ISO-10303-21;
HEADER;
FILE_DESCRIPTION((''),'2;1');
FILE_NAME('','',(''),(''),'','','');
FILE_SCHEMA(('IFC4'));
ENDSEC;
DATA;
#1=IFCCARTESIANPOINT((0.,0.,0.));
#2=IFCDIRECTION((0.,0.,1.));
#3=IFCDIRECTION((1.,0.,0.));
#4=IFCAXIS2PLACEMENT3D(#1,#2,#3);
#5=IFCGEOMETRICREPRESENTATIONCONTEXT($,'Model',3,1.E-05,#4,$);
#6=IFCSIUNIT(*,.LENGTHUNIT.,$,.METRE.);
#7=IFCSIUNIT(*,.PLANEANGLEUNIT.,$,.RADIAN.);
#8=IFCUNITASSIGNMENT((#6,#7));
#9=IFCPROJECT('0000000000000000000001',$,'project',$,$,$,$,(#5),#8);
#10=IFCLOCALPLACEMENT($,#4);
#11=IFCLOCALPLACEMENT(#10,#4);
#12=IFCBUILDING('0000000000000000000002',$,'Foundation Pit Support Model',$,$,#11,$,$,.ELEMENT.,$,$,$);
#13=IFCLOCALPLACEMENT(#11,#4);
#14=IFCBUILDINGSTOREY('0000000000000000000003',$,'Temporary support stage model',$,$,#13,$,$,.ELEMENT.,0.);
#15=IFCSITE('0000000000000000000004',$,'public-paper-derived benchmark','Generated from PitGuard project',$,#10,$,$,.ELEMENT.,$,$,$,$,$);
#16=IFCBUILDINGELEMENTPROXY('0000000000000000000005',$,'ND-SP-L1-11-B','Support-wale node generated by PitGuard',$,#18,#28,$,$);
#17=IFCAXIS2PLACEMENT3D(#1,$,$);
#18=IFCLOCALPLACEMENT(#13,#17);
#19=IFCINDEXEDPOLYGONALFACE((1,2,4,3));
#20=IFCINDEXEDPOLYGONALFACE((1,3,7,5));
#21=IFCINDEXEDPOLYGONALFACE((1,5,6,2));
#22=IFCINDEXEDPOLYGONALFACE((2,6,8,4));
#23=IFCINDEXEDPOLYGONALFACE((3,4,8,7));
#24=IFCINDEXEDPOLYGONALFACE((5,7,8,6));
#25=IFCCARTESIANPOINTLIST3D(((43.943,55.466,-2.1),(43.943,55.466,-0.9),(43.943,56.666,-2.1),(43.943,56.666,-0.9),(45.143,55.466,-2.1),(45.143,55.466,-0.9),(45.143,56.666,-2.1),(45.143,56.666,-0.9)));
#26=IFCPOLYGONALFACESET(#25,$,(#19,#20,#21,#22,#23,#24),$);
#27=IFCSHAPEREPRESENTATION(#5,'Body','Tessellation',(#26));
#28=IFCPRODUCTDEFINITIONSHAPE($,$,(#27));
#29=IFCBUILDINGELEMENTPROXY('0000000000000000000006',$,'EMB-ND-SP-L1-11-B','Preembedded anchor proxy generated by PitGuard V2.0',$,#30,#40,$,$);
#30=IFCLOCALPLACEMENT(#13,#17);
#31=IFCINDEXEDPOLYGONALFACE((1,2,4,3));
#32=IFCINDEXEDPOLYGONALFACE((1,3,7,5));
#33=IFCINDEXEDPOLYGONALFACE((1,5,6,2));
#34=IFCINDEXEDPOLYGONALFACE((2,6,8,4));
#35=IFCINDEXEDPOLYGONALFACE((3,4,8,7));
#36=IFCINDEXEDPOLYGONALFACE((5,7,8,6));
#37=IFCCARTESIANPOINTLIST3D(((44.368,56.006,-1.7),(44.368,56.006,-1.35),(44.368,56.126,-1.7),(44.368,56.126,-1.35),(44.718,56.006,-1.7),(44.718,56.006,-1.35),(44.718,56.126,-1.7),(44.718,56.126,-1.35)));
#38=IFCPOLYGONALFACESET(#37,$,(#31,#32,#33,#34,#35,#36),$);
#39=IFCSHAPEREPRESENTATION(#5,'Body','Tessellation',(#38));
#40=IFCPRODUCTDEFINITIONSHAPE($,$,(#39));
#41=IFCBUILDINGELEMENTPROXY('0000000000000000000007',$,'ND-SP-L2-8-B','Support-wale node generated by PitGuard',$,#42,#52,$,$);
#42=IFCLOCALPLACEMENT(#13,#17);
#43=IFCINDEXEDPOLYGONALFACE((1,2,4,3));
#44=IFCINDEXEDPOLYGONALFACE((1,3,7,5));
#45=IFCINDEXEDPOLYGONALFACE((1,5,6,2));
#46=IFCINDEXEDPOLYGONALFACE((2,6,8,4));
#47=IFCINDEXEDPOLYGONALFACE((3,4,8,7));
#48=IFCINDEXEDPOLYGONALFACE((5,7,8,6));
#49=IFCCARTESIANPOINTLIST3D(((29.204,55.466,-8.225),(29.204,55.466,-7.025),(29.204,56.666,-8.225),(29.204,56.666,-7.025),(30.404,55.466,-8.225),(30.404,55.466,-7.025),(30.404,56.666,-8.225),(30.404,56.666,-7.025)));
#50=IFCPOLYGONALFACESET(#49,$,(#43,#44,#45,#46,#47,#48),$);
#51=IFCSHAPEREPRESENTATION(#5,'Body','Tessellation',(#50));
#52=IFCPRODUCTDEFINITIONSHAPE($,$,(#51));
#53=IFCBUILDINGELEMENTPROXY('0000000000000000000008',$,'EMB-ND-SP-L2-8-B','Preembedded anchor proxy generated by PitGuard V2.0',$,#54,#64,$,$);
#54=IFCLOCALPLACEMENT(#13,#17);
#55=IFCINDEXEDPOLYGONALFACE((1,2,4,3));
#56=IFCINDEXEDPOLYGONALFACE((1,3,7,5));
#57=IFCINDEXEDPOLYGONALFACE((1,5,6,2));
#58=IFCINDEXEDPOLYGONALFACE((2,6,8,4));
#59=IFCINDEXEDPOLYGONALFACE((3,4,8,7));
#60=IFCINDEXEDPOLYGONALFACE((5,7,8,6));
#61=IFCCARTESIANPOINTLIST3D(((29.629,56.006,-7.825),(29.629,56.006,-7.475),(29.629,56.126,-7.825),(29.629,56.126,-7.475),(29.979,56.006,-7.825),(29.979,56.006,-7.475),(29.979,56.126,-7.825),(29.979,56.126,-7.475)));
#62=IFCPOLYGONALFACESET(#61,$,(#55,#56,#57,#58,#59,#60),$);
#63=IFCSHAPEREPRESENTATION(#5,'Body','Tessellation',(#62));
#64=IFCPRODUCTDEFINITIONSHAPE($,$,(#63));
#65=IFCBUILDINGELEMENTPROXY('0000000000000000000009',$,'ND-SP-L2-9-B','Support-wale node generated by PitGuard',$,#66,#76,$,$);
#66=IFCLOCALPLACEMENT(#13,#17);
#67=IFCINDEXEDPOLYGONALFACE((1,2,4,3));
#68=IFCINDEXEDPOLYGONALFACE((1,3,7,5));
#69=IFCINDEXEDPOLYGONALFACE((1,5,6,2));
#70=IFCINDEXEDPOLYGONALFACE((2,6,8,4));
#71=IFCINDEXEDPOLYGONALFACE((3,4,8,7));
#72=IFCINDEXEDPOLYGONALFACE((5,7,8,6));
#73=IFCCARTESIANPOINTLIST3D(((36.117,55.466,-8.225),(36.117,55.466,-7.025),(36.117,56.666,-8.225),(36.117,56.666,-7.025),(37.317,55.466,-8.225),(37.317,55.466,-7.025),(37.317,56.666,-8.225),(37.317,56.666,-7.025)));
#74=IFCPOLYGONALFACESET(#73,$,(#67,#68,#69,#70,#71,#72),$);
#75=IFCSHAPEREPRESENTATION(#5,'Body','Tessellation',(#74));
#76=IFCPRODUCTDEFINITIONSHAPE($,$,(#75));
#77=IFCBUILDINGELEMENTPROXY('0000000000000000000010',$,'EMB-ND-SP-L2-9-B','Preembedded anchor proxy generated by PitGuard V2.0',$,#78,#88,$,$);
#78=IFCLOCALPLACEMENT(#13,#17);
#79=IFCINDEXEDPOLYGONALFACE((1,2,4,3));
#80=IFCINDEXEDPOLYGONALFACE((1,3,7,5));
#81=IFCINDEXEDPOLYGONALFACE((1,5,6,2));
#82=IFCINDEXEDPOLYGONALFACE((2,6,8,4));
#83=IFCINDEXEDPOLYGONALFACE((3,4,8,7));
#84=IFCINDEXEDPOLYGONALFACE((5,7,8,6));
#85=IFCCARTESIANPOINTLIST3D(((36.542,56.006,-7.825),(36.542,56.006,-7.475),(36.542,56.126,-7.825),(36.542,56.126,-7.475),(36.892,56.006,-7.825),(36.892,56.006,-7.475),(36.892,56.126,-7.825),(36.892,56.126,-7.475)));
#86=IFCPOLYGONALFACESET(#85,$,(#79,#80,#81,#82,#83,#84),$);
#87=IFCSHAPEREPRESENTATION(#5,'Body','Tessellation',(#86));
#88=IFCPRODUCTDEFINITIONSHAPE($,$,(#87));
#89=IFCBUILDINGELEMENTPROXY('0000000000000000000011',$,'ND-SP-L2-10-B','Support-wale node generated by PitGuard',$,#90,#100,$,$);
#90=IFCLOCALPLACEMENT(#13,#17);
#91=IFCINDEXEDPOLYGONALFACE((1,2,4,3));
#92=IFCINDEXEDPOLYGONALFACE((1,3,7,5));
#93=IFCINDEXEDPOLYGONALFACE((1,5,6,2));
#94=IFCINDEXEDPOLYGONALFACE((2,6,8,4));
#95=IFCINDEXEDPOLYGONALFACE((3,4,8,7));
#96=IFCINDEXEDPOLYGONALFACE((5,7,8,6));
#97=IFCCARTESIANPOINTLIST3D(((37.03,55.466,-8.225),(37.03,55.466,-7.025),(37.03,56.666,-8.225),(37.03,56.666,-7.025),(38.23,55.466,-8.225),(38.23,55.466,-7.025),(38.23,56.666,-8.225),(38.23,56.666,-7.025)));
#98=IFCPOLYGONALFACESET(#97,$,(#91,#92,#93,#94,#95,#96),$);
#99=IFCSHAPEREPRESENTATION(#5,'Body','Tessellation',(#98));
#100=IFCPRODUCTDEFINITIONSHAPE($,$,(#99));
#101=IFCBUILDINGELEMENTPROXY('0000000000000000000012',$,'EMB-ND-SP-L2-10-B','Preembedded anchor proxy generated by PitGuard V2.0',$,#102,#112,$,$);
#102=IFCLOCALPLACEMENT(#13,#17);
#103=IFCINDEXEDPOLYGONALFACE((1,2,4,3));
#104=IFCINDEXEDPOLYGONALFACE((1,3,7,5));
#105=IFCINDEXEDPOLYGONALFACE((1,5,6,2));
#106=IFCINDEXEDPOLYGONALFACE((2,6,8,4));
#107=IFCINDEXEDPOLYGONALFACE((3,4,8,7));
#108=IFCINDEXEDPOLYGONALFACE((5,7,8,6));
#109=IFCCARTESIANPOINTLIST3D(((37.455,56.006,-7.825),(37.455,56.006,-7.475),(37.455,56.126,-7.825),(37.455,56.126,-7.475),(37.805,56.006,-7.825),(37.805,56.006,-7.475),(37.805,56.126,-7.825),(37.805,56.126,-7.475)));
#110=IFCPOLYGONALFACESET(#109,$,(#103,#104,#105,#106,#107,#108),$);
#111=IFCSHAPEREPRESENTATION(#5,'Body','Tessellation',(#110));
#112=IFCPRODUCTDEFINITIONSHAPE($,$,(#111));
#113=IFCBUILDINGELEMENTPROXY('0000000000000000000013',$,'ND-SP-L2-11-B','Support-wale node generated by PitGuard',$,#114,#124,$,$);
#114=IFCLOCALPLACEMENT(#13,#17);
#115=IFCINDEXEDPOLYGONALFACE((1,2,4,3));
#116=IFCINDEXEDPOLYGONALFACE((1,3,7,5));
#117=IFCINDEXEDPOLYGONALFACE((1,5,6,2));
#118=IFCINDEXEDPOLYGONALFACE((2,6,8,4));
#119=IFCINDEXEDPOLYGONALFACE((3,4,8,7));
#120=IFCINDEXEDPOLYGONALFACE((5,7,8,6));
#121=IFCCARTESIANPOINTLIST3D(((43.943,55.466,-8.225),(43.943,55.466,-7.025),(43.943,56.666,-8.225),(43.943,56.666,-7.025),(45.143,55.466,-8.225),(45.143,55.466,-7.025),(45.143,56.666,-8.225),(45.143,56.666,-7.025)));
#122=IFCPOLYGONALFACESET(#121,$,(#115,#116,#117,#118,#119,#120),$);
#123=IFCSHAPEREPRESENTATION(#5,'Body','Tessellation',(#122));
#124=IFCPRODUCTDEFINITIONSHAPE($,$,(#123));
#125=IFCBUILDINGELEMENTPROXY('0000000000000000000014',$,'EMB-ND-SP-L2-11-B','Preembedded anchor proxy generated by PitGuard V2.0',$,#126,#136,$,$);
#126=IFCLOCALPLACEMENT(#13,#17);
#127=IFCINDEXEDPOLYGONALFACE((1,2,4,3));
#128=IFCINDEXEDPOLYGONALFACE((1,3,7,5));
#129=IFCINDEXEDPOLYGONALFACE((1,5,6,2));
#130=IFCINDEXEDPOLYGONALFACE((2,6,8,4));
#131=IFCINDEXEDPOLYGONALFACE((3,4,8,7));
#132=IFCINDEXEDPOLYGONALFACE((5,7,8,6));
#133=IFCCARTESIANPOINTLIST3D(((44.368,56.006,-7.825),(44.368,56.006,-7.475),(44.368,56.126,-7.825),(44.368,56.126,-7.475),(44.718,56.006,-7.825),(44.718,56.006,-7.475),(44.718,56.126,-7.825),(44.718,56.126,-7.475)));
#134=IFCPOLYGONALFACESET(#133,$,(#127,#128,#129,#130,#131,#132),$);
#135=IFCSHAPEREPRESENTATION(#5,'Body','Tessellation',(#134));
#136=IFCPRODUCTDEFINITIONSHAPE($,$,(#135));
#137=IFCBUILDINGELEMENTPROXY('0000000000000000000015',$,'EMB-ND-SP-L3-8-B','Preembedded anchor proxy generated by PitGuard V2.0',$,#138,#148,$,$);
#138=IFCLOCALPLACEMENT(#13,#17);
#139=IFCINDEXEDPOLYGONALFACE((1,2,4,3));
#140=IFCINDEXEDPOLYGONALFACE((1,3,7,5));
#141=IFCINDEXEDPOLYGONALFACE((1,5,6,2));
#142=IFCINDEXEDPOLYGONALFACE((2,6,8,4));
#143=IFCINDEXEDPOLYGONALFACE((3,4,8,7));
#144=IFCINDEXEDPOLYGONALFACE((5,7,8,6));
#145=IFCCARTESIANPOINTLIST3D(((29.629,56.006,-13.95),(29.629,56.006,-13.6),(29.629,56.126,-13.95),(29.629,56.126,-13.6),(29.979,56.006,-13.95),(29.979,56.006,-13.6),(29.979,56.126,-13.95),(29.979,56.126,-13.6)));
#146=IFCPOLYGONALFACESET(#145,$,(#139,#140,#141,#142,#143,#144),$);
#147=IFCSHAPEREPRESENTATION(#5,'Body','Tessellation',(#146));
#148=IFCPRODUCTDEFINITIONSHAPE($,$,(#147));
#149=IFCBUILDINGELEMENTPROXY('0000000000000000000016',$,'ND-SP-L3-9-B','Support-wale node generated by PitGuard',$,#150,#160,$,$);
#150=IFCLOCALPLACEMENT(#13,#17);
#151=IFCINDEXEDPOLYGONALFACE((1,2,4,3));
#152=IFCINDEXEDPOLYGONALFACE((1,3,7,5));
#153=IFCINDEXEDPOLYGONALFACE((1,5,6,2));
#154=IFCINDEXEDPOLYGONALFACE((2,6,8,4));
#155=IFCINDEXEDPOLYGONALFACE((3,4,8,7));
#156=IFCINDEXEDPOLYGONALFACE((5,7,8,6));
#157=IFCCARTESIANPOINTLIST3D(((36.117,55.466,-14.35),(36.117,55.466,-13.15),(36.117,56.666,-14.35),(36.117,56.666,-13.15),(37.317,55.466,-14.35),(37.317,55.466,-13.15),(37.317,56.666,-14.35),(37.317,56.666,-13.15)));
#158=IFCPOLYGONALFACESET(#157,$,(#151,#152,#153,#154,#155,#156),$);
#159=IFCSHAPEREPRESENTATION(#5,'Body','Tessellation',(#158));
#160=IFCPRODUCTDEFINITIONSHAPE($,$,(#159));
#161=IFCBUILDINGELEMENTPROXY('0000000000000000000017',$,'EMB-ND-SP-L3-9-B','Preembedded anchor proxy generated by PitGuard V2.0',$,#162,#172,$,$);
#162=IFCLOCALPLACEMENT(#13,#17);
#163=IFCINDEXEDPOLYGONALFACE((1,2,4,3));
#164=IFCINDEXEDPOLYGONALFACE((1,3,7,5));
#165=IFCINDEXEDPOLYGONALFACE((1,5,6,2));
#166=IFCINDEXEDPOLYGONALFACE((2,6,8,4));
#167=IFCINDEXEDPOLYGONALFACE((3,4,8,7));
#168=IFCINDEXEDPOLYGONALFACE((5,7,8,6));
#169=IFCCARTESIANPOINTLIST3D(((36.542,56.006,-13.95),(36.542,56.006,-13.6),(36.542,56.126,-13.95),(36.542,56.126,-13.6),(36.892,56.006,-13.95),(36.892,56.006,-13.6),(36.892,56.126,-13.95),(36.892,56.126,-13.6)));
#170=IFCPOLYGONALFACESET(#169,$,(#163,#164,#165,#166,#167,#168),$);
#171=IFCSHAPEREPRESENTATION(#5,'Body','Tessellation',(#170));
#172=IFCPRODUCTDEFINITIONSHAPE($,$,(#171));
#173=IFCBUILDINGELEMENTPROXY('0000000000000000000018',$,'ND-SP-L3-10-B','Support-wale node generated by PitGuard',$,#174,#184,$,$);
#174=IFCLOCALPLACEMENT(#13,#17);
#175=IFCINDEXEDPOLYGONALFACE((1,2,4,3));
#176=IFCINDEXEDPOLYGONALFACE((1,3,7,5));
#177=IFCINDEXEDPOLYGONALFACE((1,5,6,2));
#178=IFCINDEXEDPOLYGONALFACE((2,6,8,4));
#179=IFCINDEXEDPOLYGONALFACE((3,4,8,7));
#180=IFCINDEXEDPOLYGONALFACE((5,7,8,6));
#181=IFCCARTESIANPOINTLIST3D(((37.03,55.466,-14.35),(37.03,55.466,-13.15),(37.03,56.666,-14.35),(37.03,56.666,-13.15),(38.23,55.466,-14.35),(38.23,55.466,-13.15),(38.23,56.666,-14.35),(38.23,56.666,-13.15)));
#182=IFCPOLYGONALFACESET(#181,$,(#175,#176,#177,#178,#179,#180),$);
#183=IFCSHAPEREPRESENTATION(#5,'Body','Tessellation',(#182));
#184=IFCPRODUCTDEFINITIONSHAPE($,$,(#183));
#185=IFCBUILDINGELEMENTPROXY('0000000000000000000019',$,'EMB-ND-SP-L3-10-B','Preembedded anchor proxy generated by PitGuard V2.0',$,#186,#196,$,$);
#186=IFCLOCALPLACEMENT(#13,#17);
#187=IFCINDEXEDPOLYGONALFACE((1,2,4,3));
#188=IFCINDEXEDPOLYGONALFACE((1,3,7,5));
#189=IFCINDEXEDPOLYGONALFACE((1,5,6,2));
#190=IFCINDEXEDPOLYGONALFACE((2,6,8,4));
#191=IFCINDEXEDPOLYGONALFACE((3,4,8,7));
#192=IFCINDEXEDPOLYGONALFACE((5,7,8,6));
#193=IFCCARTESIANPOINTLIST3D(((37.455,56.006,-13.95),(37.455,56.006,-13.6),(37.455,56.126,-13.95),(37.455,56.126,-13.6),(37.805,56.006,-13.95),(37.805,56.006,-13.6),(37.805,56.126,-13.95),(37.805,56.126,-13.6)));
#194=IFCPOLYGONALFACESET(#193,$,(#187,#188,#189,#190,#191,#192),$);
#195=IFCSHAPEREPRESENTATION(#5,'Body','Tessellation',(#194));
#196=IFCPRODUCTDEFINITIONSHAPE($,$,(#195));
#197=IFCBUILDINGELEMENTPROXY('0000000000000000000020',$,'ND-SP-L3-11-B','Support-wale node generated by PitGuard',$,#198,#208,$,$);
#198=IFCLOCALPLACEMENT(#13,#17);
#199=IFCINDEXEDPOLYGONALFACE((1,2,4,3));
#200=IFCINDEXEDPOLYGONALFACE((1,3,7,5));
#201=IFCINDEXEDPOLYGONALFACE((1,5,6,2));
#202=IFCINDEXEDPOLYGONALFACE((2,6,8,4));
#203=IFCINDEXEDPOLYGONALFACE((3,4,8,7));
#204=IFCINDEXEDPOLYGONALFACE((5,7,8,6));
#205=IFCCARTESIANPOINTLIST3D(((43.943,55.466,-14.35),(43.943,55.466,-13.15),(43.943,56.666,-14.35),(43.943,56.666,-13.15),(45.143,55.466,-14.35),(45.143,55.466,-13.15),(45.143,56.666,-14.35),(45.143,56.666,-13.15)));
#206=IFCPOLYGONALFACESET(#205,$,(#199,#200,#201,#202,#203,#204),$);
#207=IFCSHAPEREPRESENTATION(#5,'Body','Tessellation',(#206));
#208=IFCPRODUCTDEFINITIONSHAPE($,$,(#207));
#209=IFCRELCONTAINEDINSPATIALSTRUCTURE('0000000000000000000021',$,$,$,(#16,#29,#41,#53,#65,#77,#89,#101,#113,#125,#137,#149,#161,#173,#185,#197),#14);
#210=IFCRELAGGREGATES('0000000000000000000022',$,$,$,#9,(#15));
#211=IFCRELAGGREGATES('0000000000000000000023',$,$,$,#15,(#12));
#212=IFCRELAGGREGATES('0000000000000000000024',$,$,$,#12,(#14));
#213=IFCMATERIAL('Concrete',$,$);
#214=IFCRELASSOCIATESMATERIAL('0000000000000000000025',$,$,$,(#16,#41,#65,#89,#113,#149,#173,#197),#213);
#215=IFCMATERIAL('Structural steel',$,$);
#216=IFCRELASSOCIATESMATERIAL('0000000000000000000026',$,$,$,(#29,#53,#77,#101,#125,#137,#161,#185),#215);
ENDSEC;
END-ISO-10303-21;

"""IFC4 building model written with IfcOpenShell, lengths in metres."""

from ifc_helpers import new_model, si_unit, frame, origin_with_axes, origin_2d, place, context, project, spatial, rectangle, extrude, material, element, save


model = new_model("IFC4")

# Units and contexts
model_context = context("Model", 3, precision=1e-05, world=origin_with_axes())
ifc_project = project(units=[si_unit("LENGTHUNIT", "METRE"), si_unit("PLANEANGLEUNIT", "RADIAN")], contexts=[model_context])

# Site, building, storey
site_placement = place(None, origin_with_axes())
site = spatial("IfcSite", under=ifc_project, at=site_placement, Name="public-paper-derived benchmark", Description="Generated from PitGuard project", CompositionType="ELEMENT")
building_placement = place(site_placement, origin_with_axes())
building = spatial("IfcBuilding", under=site, at=building_placement, Name="Foundation Pit Support Model", CompositionType="ELEMENT")
storey_placement = place(building_placement, origin_with_axes())
storey = spatial("IfcBuildingStorey", under=building, at=storey_placement, Name="Temporary support stage model", CompositionType="ELEMENT", Elevation=0.0)

# Shared definitions
ifc_material_1 = material(Name="Structural steel")

# Building element proxies
ifc_material_2 = material(Name="Concrete")
proxy_1_placement = place(storey_placement, frame((44.543, 56.066, -2.1), z_axis=(0.0, 0.0, 1.0), x_axis=(1.0, 0.0, 0.0)))
element("IfcBuildingElementProxy", 1, at=proxy_1_placement, inside=storey, material=ifc_material_2, Name="ND-SP-L1-11-B", Description="Support-wale node generated by PitGuard", context=model_context, shape_type="SweptSolid", body=[
    extrude(rectangle(XDim=1.2, YDim=1.2, at=origin_2d()), origin_with_axes(), (0.0, 0.0, 1.0), 1.2),
])
proxy_2_placement = place(storey_placement, frame((44.543, 56.066, -1.7), z_axis=(0.0, 0.0, 1.0), x_axis=(1.0, 0.0, 0.0)))
element("IfcBuildingElementProxy", 2, at=proxy_2_placement, inside=storey, material=ifc_material_1, Name="EMB-ND-SP-L1-11-B", Description="Preembedded anchor proxy generated by PitGuard V2.0", context=model_context, shape_type="SweptSolid", body=[
    extrude(rectangle(XDim=0.35, YDim=0.12, at=origin_2d()), origin_with_axes(), (0.0, 0.0, 1.0), 0.35),
])
proxy_3_placement = place(storey_placement, frame((29.804, 56.066, -8.225), z_axis=(0.0, 0.0, 1.0), x_axis=(1.0, 0.0, 0.0)))
element("IfcBuildingElementProxy", 3, at=proxy_3_placement, inside=storey, material=ifc_material_2, Name="ND-SP-L2-8-B", Description="Support-wale node generated by PitGuard", context=model_context, shape_type="SweptSolid", body=[
    extrude(rectangle(XDim=1.2, YDim=1.2, at=origin_2d()), origin_with_axes(), (0.0, 0.0, 1.0), 1.2),
])
proxy_4_placement = place(storey_placement, frame((29.804, 56.066, -7.825), z_axis=(0.0, 0.0, 1.0), x_axis=(1.0, 0.0, 0.0)))
element("IfcBuildingElementProxy", 4, at=proxy_4_placement, inside=storey, material=ifc_material_1, Name="EMB-ND-SP-L2-8-B", Description="Preembedded anchor proxy generated by PitGuard V2.0", context=model_context, shape_type="SweptSolid", body=[
    extrude(rectangle(XDim=0.35, YDim=0.12, at=origin_2d()), origin_with_axes(), (0.0, 0.0, 1.0), 0.35),
])
proxy_5_placement = place(storey_placement, frame((36.717, 56.066, -8.225), z_axis=(0.0, 0.0, 1.0), x_axis=(1.0, 0.0, 0.0)))
element("IfcBuildingElementProxy", 5, at=proxy_5_placement, inside=storey, material=ifc_material_2, Name="ND-SP-L2-9-B", Description="Support-wale node generated by PitGuard", context=model_context, shape_type="SweptSolid", body=[
    extrude(rectangle(XDim=1.2, YDim=1.2, at=origin_2d()), origin_with_axes(), (0.0, 0.0, 1.0), 1.2),
])
proxy_6_placement = place(storey_placement, frame((36.717, 56.066, -7.825), z_axis=(0.0, 0.0, 1.0), x_axis=(1.0, 0.0, 0.0)))
element("IfcBuildingElementProxy", 6, at=proxy_6_placement, inside=storey, material=ifc_material_1, Name="EMB-ND-SP-L2-9-B", Description="Preembedded anchor proxy generated by PitGuard V2.0", context=model_context, shape_type="SweptSolid", body=[
    extrude(rectangle(XDim=0.35, YDim=0.12, at=origin_2d()), origin_with_axes(), (0.0, 0.0, 1.0), 0.35),
])
proxy_7_placement = place(storey_placement, frame((37.63, 56.066, -8.225), z_axis=(0.0, 0.0, 1.0), x_axis=(1.0, 0.0, 0.0)))
element("IfcBuildingElementProxy", 7, at=proxy_7_placement, inside=storey, material=ifc_material_2, Name="ND-SP-L2-10-B", Description="Support-wale node generated by PitGuard", context=model_context, shape_type="SweptSolid", body=[
    extrude(rectangle(XDim=1.2, YDim=1.2, at=origin_2d()), origin_with_axes(), (0.0, 0.0, 1.0), 1.2),
])
proxy_8_placement = place(storey_placement, frame((37.63, 56.066, -7.825), z_axis=(0.0, 0.0, 1.0), x_axis=(1.0, 0.0, 0.0)))
element("IfcBuildingElementProxy", 8, at=proxy_8_placement, inside=storey, material=ifc_material_1, Name="EMB-ND-SP-L2-10-B", Description="Preembedded anchor proxy generated by PitGuard V2.0", context=model_context, shape_type="SweptSolid", body=[
    extrude(rectangle(XDim=0.35, YDim=0.12, at=origin_2d()), origin_with_axes(), (0.0, 0.0, 1.0), 0.35),
])
proxy_9_placement = place(storey_placement, frame((44.543, 56.066, -8.225), z_axis=(0.0, 0.0, 1.0), x_axis=(1.0, 0.0, 0.0)))
element("IfcBuildingElementProxy", 9, at=proxy_9_placement, inside=storey, material=ifc_material_2, Name="ND-SP-L2-11-B", Description="Support-wale node generated by PitGuard", context=model_context, shape_type="SweptSolid", body=[
    extrude(rectangle(XDim=1.2, YDim=1.2, at=origin_2d()), origin_with_axes(), (0.0, 0.0, 1.0), 1.2),
])
for number, where, z_axis, x_axis, name in (
    (10, (44.543, 56.066, -7.825), (0.0, 0.0, 1.0), (1.0, 0.0, 0.0), "EMB-ND-SP-L2-11-B"),
    (11, (29.804, 56.066, -13.95), (0.0, 0.0, 1.0), (1.0, 0.0, 0.0), "EMB-ND-SP-L3-8-B"),
):
    element("IfcBuildingElementProxy", number, at=place(storey_placement, frame(where, z_axis=z_axis, x_axis=x_axis)), inside=storey, material=ifc_material_1, Name=name, Description="Preembedded anchor proxy generated by PitGuard V2.0", context=model_context, shape_type="SweptSolid", body=[
        extrude(rectangle(XDim=0.35, YDim=0.12, at=origin_2d()), origin_with_axes(), (0.0, 0.0, 1.0), 0.35),
    ])
proxy_10_placement = place(storey_placement, frame((36.717, 56.066, -14.35), z_axis=(0.0, 0.0, 1.0), x_axis=(1.0, 0.0, 0.0)))
element("IfcBuildingElementProxy", 12, at=proxy_10_placement, inside=storey, material=ifc_material_2, Name="ND-SP-L3-9-B", Description="Support-wale node generated by PitGuard", context=model_context, shape_type="SweptSolid", body=[
    extrude(rectangle(XDim=1.2, YDim=1.2, at=origin_2d()), origin_with_axes(), (0.0, 0.0, 1.0), 1.2),
])
proxy_11_placement = place(storey_placement, frame((36.717, 56.066, -13.95), z_axis=(0.0, 0.0, 1.0), x_axis=(1.0, 0.0, 0.0)))
element("IfcBuildingElementProxy", 13, at=proxy_11_placement, inside=storey, material=ifc_material_1, Name="EMB-ND-SP-L3-9-B", Description="Preembedded anchor proxy generated by PitGuard V2.0", context=model_context, shape_type="SweptSolid", body=[
    extrude(rectangle(XDim=0.35, YDim=0.12, at=origin_2d()), origin_with_axes(), (0.0, 0.0, 1.0), 0.35),
])
proxy_12_placement = place(storey_placement, frame((37.63, 56.066, -14.35), z_axis=(0.0, 0.0, 1.0), x_axis=(1.0, 0.0, 0.0)))
element("IfcBuildingElementProxy", 14, at=proxy_12_placement, inside=storey, material=ifc_material_2, Name="ND-SP-L3-10-B", Description="Support-wale node generated by PitGuard", context=model_context, shape_type="SweptSolid", body=[
    extrude(rectangle(XDim=1.2, YDim=1.2, at=origin_2d()), origin_with_axes(), (0.0, 0.0, 1.0), 1.2),
])
proxy_13_placement = place(storey_placement, frame((37.63, 56.066, -13.95), z_axis=(0.0, 0.0, 1.0), x_axis=(1.0, 0.0, 0.0)))
element("IfcBuildingElementProxy", 15, at=proxy_13_placement, inside=storey, material=ifc_material_1, Name="EMB-ND-SP-L3-10-B", Description="Preembedded anchor proxy generated by PitGuard V2.0", context=model_context, shape_type="SweptSolid", body=[
    extrude(rectangle(XDim=0.35, YDim=0.12, at=origin_2d()), origin_with_axes(), (0.0, 0.0, 1.0), 0.35),
])
proxy_14_placement = place(storey_placement, frame((44.543, 56.066, -14.35), z_axis=(0.0, 0.0, 1.0), x_axis=(1.0, 0.0, 0.0)))
element("IfcBuildingElementProxy", 16, at=proxy_14_placement, inside=storey, material=ifc_material_2, Name="ND-SP-L3-11-B", Description="Support-wale node generated by PitGuard", context=model_context, shape_type="SweptSolid", body=[
    extrude(rectangle(XDim=1.2, YDim=1.2, at=origin_2d()), origin_with_axes(), (0.0, 0.0, 1.0), 1.2),
])

save(model, "model.ifc")
